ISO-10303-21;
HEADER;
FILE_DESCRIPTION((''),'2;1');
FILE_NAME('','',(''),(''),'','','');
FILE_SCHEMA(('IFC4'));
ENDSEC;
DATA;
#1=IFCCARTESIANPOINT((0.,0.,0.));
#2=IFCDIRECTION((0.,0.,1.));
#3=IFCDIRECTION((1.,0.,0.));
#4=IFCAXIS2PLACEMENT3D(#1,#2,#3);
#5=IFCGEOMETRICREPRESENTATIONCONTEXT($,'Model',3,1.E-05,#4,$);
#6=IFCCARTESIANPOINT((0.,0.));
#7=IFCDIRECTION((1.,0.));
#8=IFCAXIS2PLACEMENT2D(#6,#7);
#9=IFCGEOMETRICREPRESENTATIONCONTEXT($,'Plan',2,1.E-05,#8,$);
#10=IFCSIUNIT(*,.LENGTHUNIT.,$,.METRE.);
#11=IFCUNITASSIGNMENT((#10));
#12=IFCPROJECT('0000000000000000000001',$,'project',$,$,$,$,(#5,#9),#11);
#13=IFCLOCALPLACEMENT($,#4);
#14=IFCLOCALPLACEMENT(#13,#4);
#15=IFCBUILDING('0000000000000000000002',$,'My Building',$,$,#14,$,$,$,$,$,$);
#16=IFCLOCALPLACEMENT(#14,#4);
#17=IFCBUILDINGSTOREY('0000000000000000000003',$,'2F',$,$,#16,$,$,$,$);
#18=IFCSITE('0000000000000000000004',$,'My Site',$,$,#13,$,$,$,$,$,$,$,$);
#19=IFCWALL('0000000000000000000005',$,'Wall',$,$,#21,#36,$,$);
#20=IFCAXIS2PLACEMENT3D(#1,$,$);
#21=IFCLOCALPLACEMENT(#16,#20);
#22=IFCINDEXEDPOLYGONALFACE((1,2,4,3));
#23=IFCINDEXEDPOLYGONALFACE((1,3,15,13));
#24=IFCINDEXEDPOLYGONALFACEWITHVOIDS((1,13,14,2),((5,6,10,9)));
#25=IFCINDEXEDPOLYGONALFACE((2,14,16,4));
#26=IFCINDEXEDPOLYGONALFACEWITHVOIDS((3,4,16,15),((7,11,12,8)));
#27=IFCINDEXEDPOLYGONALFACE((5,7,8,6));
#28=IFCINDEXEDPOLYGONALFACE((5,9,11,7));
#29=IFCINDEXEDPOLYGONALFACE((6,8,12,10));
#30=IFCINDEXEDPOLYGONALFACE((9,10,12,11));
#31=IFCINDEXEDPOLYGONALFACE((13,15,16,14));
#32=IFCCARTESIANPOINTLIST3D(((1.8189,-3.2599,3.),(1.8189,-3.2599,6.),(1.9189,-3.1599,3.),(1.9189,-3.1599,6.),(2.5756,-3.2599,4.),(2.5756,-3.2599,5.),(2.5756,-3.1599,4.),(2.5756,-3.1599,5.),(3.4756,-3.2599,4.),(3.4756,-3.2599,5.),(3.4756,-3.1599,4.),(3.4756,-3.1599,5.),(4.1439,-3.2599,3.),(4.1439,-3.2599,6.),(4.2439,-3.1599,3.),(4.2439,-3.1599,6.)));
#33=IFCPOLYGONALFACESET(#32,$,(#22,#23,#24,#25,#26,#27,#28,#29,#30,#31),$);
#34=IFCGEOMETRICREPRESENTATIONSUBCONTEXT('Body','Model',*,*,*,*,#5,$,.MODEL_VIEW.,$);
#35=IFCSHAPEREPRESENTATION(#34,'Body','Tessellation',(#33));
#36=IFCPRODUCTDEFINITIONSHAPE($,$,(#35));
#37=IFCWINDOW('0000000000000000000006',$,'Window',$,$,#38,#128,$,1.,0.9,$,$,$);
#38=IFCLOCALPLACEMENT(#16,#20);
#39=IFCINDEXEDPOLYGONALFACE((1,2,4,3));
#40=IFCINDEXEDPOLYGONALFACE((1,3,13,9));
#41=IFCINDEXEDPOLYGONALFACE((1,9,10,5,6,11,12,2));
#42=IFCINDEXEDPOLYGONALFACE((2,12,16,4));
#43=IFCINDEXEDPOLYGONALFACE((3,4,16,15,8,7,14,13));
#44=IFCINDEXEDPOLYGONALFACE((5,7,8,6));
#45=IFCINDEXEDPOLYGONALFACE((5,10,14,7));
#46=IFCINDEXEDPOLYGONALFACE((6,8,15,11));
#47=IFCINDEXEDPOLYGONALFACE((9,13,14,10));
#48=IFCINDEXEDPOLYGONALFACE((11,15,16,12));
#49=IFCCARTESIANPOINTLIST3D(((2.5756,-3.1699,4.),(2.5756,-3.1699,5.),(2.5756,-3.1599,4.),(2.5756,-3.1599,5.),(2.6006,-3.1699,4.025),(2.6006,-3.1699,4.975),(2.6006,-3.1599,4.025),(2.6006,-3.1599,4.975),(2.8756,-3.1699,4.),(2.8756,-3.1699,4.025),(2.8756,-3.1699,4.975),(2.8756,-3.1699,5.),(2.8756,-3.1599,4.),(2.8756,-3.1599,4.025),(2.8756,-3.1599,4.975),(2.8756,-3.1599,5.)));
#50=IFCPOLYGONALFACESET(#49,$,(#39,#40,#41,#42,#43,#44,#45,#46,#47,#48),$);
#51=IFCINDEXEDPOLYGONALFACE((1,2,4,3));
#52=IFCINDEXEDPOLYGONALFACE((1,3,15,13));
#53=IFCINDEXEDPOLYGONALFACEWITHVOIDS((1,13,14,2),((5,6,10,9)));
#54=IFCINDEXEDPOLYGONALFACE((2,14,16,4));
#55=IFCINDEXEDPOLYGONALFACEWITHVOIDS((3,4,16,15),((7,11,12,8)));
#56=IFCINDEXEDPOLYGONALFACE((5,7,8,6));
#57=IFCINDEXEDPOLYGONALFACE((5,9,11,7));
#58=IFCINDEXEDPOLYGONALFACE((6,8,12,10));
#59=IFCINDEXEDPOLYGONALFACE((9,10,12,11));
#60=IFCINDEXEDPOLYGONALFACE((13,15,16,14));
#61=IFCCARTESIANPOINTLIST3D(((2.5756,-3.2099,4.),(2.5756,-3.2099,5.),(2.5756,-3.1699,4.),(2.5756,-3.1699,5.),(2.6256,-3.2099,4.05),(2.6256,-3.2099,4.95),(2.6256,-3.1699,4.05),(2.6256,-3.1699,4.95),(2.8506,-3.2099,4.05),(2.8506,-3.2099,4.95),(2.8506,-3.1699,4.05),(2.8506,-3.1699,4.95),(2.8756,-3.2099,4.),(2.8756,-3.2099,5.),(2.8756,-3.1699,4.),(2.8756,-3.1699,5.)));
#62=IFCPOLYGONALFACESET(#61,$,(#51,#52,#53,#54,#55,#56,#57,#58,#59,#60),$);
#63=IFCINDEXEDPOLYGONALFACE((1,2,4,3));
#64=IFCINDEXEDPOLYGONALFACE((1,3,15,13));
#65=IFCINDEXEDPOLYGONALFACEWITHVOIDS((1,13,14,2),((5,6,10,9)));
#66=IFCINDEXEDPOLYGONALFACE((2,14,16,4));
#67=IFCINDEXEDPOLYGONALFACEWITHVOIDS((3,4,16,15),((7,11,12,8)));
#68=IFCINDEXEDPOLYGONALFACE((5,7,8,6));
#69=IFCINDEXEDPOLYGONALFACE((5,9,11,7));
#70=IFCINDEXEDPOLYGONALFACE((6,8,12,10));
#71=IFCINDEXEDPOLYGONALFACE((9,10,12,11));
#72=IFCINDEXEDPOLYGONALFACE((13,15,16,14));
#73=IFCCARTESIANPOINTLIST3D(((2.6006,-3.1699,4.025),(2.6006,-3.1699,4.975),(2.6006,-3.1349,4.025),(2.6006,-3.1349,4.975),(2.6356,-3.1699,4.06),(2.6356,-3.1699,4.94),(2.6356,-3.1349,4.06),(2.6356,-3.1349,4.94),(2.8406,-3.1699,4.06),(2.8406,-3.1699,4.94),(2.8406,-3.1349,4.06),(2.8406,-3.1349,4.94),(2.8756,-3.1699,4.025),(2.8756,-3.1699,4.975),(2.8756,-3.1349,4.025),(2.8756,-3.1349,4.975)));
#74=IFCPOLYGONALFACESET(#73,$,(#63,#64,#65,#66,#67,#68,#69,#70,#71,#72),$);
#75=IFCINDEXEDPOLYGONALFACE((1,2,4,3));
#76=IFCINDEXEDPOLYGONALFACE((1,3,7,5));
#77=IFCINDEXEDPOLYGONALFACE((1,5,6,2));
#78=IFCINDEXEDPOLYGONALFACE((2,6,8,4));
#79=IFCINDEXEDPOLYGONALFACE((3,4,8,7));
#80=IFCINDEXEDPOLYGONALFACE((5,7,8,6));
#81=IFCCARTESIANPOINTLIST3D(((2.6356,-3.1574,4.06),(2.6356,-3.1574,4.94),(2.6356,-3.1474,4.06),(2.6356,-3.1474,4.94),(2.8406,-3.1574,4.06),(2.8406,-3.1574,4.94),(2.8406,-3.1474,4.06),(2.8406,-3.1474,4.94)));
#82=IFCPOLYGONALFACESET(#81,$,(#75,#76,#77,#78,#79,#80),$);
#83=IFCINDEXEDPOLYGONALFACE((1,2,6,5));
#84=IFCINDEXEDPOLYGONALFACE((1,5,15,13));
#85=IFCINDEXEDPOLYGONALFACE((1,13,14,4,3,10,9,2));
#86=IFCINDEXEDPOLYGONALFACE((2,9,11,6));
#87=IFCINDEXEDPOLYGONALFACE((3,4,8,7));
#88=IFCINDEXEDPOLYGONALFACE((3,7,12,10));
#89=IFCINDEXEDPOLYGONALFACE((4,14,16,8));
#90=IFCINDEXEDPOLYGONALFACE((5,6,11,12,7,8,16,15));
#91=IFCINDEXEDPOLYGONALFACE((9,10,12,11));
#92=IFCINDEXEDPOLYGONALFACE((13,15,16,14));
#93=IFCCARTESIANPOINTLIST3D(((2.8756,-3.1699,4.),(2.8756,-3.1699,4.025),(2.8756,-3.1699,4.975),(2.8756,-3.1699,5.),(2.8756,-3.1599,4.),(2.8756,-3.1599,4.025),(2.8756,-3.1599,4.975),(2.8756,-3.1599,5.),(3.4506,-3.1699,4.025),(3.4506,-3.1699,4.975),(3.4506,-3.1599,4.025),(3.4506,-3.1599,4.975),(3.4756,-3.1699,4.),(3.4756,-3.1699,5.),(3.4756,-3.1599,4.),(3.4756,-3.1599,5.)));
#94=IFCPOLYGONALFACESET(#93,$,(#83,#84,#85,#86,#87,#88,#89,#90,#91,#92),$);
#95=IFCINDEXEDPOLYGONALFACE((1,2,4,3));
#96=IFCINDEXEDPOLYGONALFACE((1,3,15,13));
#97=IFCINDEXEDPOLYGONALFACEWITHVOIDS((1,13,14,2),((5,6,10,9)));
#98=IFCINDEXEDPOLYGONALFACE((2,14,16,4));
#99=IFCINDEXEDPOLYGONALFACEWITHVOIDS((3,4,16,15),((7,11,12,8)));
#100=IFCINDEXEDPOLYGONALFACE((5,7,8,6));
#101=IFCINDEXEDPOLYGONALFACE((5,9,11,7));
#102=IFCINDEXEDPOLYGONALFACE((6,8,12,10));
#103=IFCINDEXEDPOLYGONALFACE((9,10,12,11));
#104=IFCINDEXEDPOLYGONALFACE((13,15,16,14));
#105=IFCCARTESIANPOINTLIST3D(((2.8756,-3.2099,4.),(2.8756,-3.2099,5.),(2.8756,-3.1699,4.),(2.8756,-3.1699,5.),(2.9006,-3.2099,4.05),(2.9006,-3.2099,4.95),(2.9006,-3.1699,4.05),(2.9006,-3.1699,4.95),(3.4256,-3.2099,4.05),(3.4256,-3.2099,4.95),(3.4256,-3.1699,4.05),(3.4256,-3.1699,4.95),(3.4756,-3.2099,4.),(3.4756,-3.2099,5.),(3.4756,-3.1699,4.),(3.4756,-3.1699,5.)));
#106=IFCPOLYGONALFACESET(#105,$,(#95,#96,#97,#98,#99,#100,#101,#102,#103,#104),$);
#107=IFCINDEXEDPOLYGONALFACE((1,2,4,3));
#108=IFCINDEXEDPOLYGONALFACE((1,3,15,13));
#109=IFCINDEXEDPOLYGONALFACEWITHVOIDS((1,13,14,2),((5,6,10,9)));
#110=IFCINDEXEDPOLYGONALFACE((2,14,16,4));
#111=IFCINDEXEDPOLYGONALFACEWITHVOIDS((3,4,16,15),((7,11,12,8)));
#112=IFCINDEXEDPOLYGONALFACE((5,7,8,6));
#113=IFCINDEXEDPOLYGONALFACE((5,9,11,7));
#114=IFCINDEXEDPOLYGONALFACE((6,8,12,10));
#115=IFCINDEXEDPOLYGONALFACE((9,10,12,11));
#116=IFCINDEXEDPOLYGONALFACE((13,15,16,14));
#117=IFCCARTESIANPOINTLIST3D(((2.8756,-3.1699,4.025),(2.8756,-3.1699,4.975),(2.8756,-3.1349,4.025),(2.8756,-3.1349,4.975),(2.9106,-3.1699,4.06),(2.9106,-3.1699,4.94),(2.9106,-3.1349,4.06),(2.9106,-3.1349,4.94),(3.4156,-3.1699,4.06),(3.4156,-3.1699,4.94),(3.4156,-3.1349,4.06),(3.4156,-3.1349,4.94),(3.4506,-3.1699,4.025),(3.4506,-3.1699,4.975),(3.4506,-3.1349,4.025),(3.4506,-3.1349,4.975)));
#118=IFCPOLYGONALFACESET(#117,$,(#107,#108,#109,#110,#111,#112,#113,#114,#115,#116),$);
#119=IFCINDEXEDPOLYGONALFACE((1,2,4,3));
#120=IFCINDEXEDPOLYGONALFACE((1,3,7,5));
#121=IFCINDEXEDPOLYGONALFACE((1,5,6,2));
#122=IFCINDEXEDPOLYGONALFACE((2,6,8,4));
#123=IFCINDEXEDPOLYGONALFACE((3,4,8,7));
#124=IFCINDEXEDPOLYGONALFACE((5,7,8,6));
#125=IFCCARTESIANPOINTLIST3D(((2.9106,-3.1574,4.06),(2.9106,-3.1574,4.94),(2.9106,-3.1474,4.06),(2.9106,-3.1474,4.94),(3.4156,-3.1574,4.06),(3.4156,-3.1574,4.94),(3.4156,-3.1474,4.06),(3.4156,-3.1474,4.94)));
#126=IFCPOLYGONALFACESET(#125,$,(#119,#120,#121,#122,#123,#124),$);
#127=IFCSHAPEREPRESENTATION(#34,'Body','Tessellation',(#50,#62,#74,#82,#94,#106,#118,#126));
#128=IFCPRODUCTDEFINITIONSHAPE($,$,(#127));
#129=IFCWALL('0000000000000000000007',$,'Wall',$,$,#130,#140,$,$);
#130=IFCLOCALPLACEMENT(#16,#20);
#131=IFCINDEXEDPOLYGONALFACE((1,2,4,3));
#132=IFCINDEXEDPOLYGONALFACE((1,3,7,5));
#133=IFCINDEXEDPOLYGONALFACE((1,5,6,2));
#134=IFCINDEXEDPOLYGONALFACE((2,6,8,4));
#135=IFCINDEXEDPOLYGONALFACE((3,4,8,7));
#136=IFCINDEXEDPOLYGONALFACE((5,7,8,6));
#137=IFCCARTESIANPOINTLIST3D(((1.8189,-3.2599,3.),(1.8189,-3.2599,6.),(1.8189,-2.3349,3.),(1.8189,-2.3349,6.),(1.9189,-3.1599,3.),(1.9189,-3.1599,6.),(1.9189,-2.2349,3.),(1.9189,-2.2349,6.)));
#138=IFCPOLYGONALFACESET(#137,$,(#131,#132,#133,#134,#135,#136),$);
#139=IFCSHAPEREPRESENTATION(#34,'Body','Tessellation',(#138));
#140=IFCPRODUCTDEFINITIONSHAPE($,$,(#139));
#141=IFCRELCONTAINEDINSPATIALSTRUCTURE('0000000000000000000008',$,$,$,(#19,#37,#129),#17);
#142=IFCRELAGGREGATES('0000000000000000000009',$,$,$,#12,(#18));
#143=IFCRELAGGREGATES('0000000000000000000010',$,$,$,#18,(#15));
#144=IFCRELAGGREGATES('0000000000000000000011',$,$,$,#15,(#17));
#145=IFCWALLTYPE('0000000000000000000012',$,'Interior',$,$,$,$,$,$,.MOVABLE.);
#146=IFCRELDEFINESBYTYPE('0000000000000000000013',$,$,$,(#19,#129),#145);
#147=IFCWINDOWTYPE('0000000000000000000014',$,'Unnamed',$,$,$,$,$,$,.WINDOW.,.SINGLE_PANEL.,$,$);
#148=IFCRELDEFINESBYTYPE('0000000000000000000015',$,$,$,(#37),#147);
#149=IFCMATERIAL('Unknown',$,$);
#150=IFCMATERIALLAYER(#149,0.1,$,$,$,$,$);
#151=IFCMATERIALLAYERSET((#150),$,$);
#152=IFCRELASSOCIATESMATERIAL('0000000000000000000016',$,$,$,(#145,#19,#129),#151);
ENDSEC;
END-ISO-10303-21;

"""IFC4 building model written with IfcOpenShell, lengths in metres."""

from ifc_helpers import new_model, entity, si_unit, frame, origin_with_axes, origin_2d_with_axis, place, context, subcontext, project, spatial, line, indexed_curve, outline, extrude, shape, source, transform, mapped, material, layer, layer_set, layer_usage, type_object, type_shapes, element, fill, save


model = new_model("IFC4")

# Units and contexts
model_context = context("Model", 3, precision=1e-05, world=origin_with_axes())
plan_context = context("Plan", 2, precision=1e-05, world=origin_2d_with_axis())
body_context_1 = subcontext(model_context, "Body", "Model", "MODEL_VIEW")
body_context_2 = subcontext(plan_context, "Body", "Plan", "PLAN_VIEW")
ifc_project = project(units=[si_unit("LENGTHUNIT", "METRE")], contexts=[model_context, plan_context])

# Site, building, storey
site_placement = place(None, origin_with_axes())
site = spatial("IfcSite", under=ifc_project, at=site_placement, Name="My Site")
building_placement = place(site_placement, origin_with_axes())
building = spatial("IfcBuilding", under=site, at=building_placement, Name="My Building")
storey_placement = place(building_placement, origin_with_axes())
storey = spatial("IfcBuildingStorey", under=building, at=storey_placement, Name="2F")

# Shared definitions
ifc_material = material(Name="Unknown")

# Shared definitions
ifc_layer_1 = layer(ifc_material, 0.1)
ifc_layer_set_1 = layer_set([ifc_layer_1])
wall_type = type_object("IfcWallType", Name="Interior", PredefinedType="MOVABLE", material=ifc_layer_set_1)

# Shared definitions
shared_shape_1 = source(origin_with_axes(), body_context_1, "Body", "SweptSolid", [
    extrude(outline(indexed_curve([(0.0, 0.0), (0.9, 0.0), (0.9, 1.0), (0.0, 1.0)], segments=[line(1, 2, 3, 4, 1)])), frame((0.0, -0.6, 0.0), z_axis=(0.0, -1.0, 0.0), x_axis=(1.0, 0.0, 0.0)), (0.0, 0.0, -1.0), 1.2),
])
window_type = type_object("IfcWindowType", Name="Unnamed", PartitioningType="SINGLE_PANEL", PredefinedType="WINDOW")
shared_shape_2 = source(origin_with_axes(), body_context_1, "Body", "SweptSolid", [
    extrude(outline(indexed_curve([(0.3, 0.0), (0.0, 0.0), (0.0, 1.0), (0.3, 1.0), (0.3, 0.975), (0.025, 0.975), (0.025, 0.025), (0.3, 0.025)], segments=[line(1, 2, 3, 4, 5, 6, 7, 8, 1)])), frame((0.0, 0.09, 0.0), z_axis=(0.0, -1.0, 0.0), x_axis=(1.0, 0.0, 0.0)), (0.0, 0.0, -1.0), 0.01),
    extrude(outline(indexed_curve([(0.0, 0.0), (0.3, 0.0), (0.3, 1.0), (0.0, 1.0)], segments=[line(1, 2, 3, 4, 1)]), holes=[indexed_curve([(0.05, 0.05), (0.275, 0.05), (0.275, 0.95), (0.05, 0.95)], segments=[line(1, 2, 3, 4, 1)])]), frame((0.0, 0.05, 0.0), z_axis=(0.0, -1.0, 0.0), x_axis=(1.0, 0.0, 0.0)), (0.0, 0.0, -1.0), 0.04),
    extrude(outline(indexed_curve([(0.0, 0.0), (0.275, 0.0), (0.275, 0.95), (0.0, 0.95)], segments=[line(1, 2, 3, 4, 1)]), holes=[indexed_curve([(0.035, 0.035), (0.24, 0.035), (0.24, 0.915), (0.035, 0.915)], segments=[line(1, 2, 3, 4, 1)])]), frame((0.025, 0.09, 0.025), z_axis=(0.0, -1.0, 0.0), x_axis=(1.0, 0.0, 0.0)), (0.0, 0.0, -1.0), 0.035),
    extrude(outline(indexed_curve([(0.035, 0.035), (0.24, 0.035), (0.24, 0.915), (0.035, 0.915)], segments=[line(1, 2, 3, 4, 1)])), frame((0.025, 0.1025, 0.025), z_axis=(0.0, -1.0, 0.0), x_axis=(1.0, 0.0, 0.0)), (0.0, 0.0, -1.0), 0.01),
    extrude(outline(indexed_curve([(0.0, 1.0), (0.6, 1.0), (0.6, 0.0), (0.0, 0.0), (0.0, 0.025), (0.575, 0.025), (0.575, 0.975), (0.0, 0.975)], segments=[line(1, 2, 3, 4, 5, 6, 7, 8, 1)])), frame((0.3, 0.09, 0.0), z_axis=(0.0, -1.0, 0.0), x_axis=(1.0, 0.0, 0.0)), (0.0, 0.0, -1.0), 0.01),
    extrude(outline(indexed_curve([(0.0, 0.0), (0.6, 0.0), (0.6, 1.0), (0.0, 1.0)], segments=[line(1, 2, 3, 4, 1)]), holes=[indexed_curve([(0.025, 0.05), (0.55, 0.05), (0.55, 0.95), (0.025, 0.95)], segments=[line(1, 2, 3, 4, 1)])]), frame((0.3, 0.05, 0.0), z_axis=(0.0, -1.0, 0.0), x_axis=(1.0, 0.0, 0.0)), (0.0, 0.0, -1.0), 0.04),
    extrude(outline(indexed_curve([(0.0, 0.0), (0.575, 0.0), (0.575, 0.95), (0.0, 0.95)], segments=[line(1, 2, 3, 4, 1)]), holes=[indexed_curve([(0.035, 0.035), (0.54, 0.035), (0.54, 0.915), (0.035, 0.915)], segments=[line(1, 2, 3, 4, 1)])]), frame((0.3, 0.09, 0.025), z_axis=(0.0, -1.0, 0.0), x_axis=(1.0, 0.0, 0.0)), (0.0, 0.0, -1.0), 0.035),
    extrude(outline(indexed_curve([(0.035, 0.035), (0.54, 0.035), (0.54, 0.915), (0.035, 0.915)], segments=[line(1, 2, 3, 4, 1)])), frame((0.3, 0.1025, 0.025), z_axis=(0.0, -1.0, 0.0), x_axis=(1.0, 0.0, 0.0)), (0.0, 0.0, -1.0), 0.01),
])
shared_shape_3 = source(origin_with_axes(), body_context_2, "Body", "Curve2D", [
    entity("IfcIndexedPolyCurve", entity("IfcCartesianPointList2D", [[0.05, 0.05], [0.275, 0.05]])),
    entity("IfcIndexedPolyCurve", entity("IfcCartesianPointList2D", [[0.0, 0.1], [0.025, 0.1], [0.025, 0.09], [0.05, 0.09], [0.05, 0.05], [0.0, 0.05]]), [entity("IfcLineIndex", [1, 2, 3, 4, 5, 6, 1])]),
    entity("IfcIndexedPolyCurve", entity("IfcCartesianPointList2D", [[0.3, 0.1], [0.3, 0.1], [0.3, 0.09], [0.275, 0.09], [0.275, 0.05], [0.3, 0.05]])),
    entity("IfcIndexedPolyCurve", entity("IfcCartesianPointList2D", [[0.025, 0.09], [0.06, 0.09], [0.06, 0.125], [0.025, 0.125]]), [entity("IfcLineIndex", [1, 2, 3, 4, 1])]),
    entity("IfcIndexedPolyCurve", entity("IfcCartesianPointList2D", [[0.3, 0.09], [0.265, 0.09], [0.265, 0.125], [0.3, 0.125]]), [entity("IfcLineIndex", [1, 2, 3, 4, 1])]),
    entity("IfcIndexedPolyCurve", entity("IfcCartesianPointList2D", [[0.06, 0.09], [0.265, 0.09]])),
    entity("IfcIndexedPolyCurve", entity("IfcCartesianPointList2D", [[0.06, 0.125], [0.265, 0.125]])),
    entity("IfcIndexedPolyCurve", entity("IfcCartesianPointList2D", [[0.06, 0.1075], [0.265, 0.1075]])),
    entity("IfcIndexedPolyCurve", entity("IfcCartesianPointList2D", [[0.325, 0.05], [0.85, 0.05]])),
    entity("IfcIndexedPolyCurve", entity("IfcCartesianPointList2D", [[0.3, 0.1], [0.3, 0.1], [0.3, 0.09], [0.325, 0.09], [0.325, 0.05], [0.3, 0.05]])),
    entity("IfcIndexedPolyCurve", entity("IfcCartesianPointList2D", [[0.9, 0.1], [0.875, 0.1], [0.875, 0.09], [0.85, 0.09], [0.85, 0.05], [0.9, 0.05]]), [entity("IfcLineIndex", [1, 2, 3, 4, 5, 6, 1])]),
    entity("IfcIndexedPolyCurve", entity("IfcCartesianPointList2D", [[0.3, 0.09], [0.335, 0.09], [0.335, 0.125], [0.3, 0.125]]), [entity("IfcLineIndex", [1, 2, 3, 4, 1])]),
    entity("IfcIndexedPolyCurve", entity("IfcCartesianPointList2D", [[0.875, 0.09], [0.84, 0.09], [0.84, 0.125], [0.875, 0.125]]), [entity("IfcLineIndex", [1, 2, 3, 4, 1])]),
    entity("IfcIndexedPolyCurve", entity("IfcCartesianPointList2D", [[0.335, 0.09], [0.84, 0.09]])),
    entity("IfcIndexedPolyCurve", entity("IfcCartesianPointList2D", [[0.335, 0.125], [0.84, 0.125]])),
    entity("IfcIndexedPolyCurve", entity("IfcCartesianPointList2D", [[0.335, 0.1075], [0.84, 0.1075]])),
])
type_shapes(window_type, [shared_shape_2, shared_shape_3])

# Wall, opening, window
ifc_layer_usage_1 = layer_usage(ifc_layer_set_1, "AXIS2", "POSITIVE", 0.0)
wall_1_placement = place(storey_placement, frame((4.1439, -3.1599, 3.0), z_axis=(0.0, 0.0, 1.0), x_axis=(-1.0, 0.0, 0.0)))
wall_1 = element("IfcWall", 1, at=wall_1_placement, inside=storey, type_object=wall_type, material=ifc_layer_usage_1, Name="Wall", context=body_context_1, shape_type="SweptSolid", body=[
    extrude(outline(indexed_curve([(-0.1, 0.0), (0.0, 0.1), (2.325, 0.1), (2.225, 0.0)], segments=[line(1, 2, 3, 4, 1)])), origin_with_axes(), (0.0, 0.0, 1.0), 3.0),
])
opening_1_placement = place(wall_1_placement, frame((1.5683, 0.1, 1.0), z_axis=(0.0, 0.0, 1.0), x_axis=(-1.0, 0.0, 0.0)))
opening_1 = element("IfcOpeningElement", 2, at=opening_1_placement, cuts=wall_1, PredefinedType="OPENING", context=body_context_1, shape_type="MappedRepresentation", body=[
    mapped(shared_shape_1, transform((0.0, 0.0, 0.0), x_axis=(1.0, 0.0, 0.0), y_axis=(0.0, 1.0, 0.0), z_axis=(0.0, 0.0, 1.0), scale=1.0)),
])
window_1_placement = place(opening_1_placement, frame((0.0, 0.0, 0.0), z_axis=(0.0, 0.0, 1.0), x_axis=(1.0, 0.0, 0.0)))
window_1 = element("IfcWindow", 3, at=window_1_placement, inside=storey, type_object=window_type, Name="Window", OverallHeight=1.0, OverallWidth=0.9, shapes=[
    shape(body_context_1, "Body", "MappedRepresentation", [mapped(shared_shape_2, transform((0.0, 0.0, 0.0), x_axis=(1.0, 0.0, 0.0), y_axis=(0.0, 1.0, 0.0), z_axis=(0.0, 0.0, 1.0), scale=1.0))]),
    shape(body_context_2, "Body", "MappedRepresentation", [mapped(shared_shape_3, transform((0.0, 0.0, 0.0), x_axis=(1.0, 0.0, 0.0), y_axis=(0.0, 1.0, 0.0), z_axis=(0.0, 0.0, 1.0), scale=1.0))]),
])
fill(opening_1, window_1)

# Wall
ifc_layer_usage_2 = layer_usage(ifc_layer_set_1, "AXIS2", "POSITIVE", 0.0)
wall_2_placement = place(storey_placement, frame((1.9189, -3.1599, 3.0), z_axis=(0.0, 0.0, 1.0), x_axis=(0.0, 1.0, 0.0)))
element("IfcWall", 4, at=wall_2_placement, inside=storey, type_object=wall_type, material=ifc_layer_usage_2, Name="Wall", context=body_context_1, shape_type="SweptSolid", body=[
    extrude(outline(indexed_curve([(0.0, 0.0), (-0.1, 0.1), (0.825, 0.1), (0.925, 0.0)], segments=[line(1, 2, 3, 4, 1)])), origin_with_axes(), (0.0, 0.0, 1.0), 3.0),
])

save(model, "model.ifc")
